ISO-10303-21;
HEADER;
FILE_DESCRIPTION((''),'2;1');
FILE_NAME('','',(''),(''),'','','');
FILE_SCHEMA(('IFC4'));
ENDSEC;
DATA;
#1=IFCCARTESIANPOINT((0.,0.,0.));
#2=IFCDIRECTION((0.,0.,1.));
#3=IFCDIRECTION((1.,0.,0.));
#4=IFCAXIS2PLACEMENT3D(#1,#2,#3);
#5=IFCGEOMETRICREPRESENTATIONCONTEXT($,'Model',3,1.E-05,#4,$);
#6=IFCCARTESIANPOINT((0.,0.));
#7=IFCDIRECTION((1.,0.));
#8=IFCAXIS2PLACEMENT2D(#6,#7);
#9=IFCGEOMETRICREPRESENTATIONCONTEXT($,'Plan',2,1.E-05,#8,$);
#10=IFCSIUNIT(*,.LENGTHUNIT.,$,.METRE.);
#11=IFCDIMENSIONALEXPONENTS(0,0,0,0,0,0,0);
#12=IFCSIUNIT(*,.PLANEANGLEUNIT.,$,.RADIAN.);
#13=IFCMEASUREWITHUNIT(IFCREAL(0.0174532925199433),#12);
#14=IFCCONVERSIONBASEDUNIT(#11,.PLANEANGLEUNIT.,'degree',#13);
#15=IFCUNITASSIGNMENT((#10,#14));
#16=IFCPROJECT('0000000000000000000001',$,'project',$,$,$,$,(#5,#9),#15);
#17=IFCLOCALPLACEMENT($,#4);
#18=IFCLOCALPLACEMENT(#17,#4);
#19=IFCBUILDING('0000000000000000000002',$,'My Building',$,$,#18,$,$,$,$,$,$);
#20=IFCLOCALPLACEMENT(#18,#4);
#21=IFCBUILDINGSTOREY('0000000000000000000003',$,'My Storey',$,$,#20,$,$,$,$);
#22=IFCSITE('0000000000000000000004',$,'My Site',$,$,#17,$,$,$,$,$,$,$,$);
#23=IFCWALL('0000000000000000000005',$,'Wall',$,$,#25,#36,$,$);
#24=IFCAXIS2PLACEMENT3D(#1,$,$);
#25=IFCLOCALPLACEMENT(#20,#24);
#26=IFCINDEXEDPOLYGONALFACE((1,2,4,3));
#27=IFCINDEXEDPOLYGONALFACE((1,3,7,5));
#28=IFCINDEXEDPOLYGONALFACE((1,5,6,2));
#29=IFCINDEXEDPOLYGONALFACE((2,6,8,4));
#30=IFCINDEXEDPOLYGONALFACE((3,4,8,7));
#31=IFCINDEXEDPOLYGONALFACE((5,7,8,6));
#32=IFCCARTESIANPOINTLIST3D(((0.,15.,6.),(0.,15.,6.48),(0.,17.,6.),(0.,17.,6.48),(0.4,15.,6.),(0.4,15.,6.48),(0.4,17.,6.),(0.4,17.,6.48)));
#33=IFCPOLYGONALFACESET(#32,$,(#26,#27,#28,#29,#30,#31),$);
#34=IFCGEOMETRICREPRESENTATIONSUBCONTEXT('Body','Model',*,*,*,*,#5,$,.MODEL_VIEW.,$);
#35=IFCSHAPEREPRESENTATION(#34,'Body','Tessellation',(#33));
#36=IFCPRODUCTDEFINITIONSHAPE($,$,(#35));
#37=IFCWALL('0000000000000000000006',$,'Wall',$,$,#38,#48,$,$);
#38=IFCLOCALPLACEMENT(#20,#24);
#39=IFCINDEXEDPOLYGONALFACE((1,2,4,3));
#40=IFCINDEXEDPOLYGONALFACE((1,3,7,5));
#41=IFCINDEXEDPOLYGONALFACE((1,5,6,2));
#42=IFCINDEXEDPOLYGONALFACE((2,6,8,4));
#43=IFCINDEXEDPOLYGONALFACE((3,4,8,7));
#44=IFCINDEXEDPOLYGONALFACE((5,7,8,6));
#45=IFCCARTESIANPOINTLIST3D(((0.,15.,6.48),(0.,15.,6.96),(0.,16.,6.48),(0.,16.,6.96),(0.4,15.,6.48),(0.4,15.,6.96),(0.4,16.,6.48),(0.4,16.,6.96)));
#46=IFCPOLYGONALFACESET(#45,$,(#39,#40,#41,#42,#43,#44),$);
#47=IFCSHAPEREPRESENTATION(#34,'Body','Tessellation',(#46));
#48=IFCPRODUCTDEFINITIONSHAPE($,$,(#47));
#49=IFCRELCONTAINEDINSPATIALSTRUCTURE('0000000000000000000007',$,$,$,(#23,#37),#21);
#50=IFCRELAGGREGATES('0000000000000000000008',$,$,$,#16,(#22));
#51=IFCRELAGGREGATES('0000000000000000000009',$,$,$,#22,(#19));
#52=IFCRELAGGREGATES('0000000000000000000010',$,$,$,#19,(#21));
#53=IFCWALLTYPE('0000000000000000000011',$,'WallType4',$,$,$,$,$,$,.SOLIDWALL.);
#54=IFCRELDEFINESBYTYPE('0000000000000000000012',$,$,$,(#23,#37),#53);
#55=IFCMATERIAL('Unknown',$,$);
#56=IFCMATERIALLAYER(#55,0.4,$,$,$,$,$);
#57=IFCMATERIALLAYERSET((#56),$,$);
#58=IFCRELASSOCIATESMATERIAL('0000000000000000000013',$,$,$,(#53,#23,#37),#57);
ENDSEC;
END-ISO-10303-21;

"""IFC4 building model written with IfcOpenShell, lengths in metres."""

from ifc_helpers import new_model, entity, si_unit, converted_unit, frame, origin_with_axes, origin_2d_with_axis, place, context, subcontext, project, spatial, indexed_curve, outline, extrude, material, layer, layer_set, layer_usage, type_object, element, save


model = new_model("IFC4")

# Units and contexts
model_context = context("Model", 3, precision=1e-05, world=origin_with_axes())
plan_context = context("Plan", 2, precision=1e-05, world=origin_2d_with_axis())
body_context_1 = subcontext(model_context, "Body", "Model", "MODEL_VIEW")
ifc_project = project(units=[si_unit("LENGTHUNIT", "METRE"), converted_unit("PLANEANGLEUNIT", "degree", entity("IfcReal", 0.0174532925199433), si_unit("PLANEANGLEUNIT", "RADIAN"), dimensions=[0, 0, 0, 0, 0, 0, 0])], contexts=[model_context, plan_context])

# Site, building, storey
site_placement = place(None, origin_with_axes())
site = spatial("IfcSite", under=ifc_project, at=site_placement, Name="My Site")
building_placement = place(site_placement, origin_with_axes())
building = spatial("IfcBuilding", under=site, at=building_placement, Name="My Building")
storey_placement = place(building_placement, origin_with_axes())
storey = spatial("IfcBuildingStorey", under=building, at=storey_placement, Name="My Storey")

# Shared definitions
ifc_material = material(Name="Unknown")

# Shared definitions
ifc_layer_1 = layer(ifc_material, 0.4)
ifc_layer_set_1 = layer_set([ifc_layer_1])
wall_type_1 = type_object("IfcWallType", Name="WallType4", PredefinedType="SOLIDWALL", material=ifc_layer_set_1)

# Walls
ifc_layer_usage_1 = layer_usage(ifc_layer_set_1, "AXIS2", "POSITIVE", 0.0)
wall_1_placement = place(storey_placement, frame((0.4, 15.0, 6.0), z_axis=(0.0, 0.0, 1.0), x_axis=(0.0, 1.0, 0.0)))
element("IfcWall", 1, at=wall_1_placement, inside=storey, type_object=wall_type_1, material=ifc_layer_usage_1, Name="Wall", context=body_context_1, shape_type="SweptSolid", body=[
    extrude(outline(indexed_curve([(0.0, 0.0), (0.0, 0.4), (2.0, 0.4), (2.0, 0.0), (0.0, 0.0)], self_intersect=False)), origin_with_axes(), (0.0, 0.0, 1.0), 0.48),
])
ifc_layer_usage_2 = layer_usage(ifc_layer_set_1, "AXIS2", "POSITIVE", 0.0)
wall_2_placement = place(storey_placement, frame((0.4, 15.0, 6.48), z_axis=(0.0, 0.0, 1.0), x_axis=(0.0, 1.0, 0.0)))
element("IfcWall", 2, at=wall_2_placement, inside=storey, type_object=wall_type_1, material=ifc_layer_usage_2, Name="Wall", context=body_context_1, shape_type="SweptSolid", body=[
    extrude(outline(indexed_curve([(0.0, 0.0), (0.0, 0.4), (1.0, 0.4), (1.0, 0.0), (0.0, 0.0)], self_intersect=False)), origin_with_axes(), (0.0, 0.0, 1.0), 0.48),
])

save(model, "model.ifc")
